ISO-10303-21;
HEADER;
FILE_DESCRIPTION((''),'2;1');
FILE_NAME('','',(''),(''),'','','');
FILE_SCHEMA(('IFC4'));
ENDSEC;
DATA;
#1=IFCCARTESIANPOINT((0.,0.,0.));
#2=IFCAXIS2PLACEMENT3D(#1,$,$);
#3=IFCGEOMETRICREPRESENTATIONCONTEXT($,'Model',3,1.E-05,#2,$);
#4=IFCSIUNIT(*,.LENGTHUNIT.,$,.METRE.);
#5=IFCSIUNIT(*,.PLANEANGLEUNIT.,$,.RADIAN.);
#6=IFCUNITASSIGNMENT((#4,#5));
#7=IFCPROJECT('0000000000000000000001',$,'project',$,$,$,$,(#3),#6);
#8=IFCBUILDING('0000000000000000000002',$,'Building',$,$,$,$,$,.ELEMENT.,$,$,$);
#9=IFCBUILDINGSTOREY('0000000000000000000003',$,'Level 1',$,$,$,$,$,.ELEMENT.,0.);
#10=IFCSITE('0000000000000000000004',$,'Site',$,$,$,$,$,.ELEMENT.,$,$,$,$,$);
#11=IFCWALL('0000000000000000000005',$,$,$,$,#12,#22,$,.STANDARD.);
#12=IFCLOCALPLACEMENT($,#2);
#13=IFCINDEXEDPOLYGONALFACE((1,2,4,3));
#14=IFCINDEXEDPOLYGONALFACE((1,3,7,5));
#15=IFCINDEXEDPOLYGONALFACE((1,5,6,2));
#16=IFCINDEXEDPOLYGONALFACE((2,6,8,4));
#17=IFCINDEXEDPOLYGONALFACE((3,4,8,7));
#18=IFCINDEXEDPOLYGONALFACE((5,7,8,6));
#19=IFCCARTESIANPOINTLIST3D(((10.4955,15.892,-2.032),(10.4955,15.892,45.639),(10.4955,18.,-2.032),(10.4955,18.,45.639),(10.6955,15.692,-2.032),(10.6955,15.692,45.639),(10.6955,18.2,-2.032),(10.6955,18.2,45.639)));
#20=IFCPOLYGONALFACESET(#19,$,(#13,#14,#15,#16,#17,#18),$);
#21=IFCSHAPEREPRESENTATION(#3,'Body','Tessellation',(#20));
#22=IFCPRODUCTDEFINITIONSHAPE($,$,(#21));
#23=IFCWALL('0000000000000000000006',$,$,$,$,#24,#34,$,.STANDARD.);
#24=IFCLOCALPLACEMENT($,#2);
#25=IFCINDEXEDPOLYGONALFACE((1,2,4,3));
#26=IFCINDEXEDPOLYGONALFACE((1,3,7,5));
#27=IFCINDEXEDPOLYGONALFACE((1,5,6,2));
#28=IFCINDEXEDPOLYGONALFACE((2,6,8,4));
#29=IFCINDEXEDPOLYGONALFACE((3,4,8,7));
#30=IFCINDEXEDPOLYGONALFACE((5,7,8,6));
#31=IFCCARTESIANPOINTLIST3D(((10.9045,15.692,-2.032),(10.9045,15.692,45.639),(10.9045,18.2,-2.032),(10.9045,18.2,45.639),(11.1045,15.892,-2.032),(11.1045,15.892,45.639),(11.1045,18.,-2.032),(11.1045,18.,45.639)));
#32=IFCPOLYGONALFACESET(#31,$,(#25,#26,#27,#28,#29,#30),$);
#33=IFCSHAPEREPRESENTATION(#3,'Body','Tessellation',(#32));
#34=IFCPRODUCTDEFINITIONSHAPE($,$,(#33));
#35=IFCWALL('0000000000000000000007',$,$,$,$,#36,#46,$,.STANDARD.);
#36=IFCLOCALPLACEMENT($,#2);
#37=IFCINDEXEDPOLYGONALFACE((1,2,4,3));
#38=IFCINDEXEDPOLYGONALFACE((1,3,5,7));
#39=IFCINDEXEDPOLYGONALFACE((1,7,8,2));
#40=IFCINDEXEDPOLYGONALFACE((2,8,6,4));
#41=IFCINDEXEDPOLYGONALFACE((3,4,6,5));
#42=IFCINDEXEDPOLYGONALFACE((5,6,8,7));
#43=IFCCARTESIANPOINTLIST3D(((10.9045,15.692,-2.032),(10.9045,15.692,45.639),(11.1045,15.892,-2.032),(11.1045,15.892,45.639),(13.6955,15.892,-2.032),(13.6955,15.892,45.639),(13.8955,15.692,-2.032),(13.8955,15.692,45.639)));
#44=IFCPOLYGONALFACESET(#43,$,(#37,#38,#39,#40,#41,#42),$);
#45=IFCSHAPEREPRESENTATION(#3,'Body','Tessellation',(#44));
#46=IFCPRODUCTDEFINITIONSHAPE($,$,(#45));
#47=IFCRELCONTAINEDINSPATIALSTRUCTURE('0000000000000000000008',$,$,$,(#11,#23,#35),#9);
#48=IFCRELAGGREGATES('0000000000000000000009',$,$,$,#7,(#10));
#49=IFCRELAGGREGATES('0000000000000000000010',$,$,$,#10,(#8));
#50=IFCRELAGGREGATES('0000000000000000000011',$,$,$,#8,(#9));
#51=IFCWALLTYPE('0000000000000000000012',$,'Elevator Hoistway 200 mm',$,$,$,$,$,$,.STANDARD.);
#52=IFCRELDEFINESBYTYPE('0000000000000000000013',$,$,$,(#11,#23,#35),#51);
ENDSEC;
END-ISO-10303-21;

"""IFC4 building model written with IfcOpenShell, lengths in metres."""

from ifc_helpers import new_model, si_unit, frame, origin, place, context, project, spatial, polyline, outline, extrude, type_object, element, save


model = new_model("IFC4")

# Units and contexts
model_context = context("Model", 3, precision=1e-05, world=origin())
ifc_project = project(units=[si_unit("LENGTHUNIT", "METRE"), si_unit("PLANEANGLEUNIT", "RADIAN")], contexts=[model_context])

# Site, building, storey
site = spatial("IfcSite", under=ifc_project, Name="Site", CompositionType="ELEMENT")
building = spatial("IfcBuilding", under=site, Name="Building", CompositionType="ELEMENT")
storey = spatial("IfcBuildingStorey", under=building, Name="Level 1", CompositionType="ELEMENT", Elevation=0.0)

# Wall
wall_type = type_object("IfcWallType", Name="Elevator Hoistway 200 mm", PredefinedType="STANDARD")
wall_1_placement = place(None, frame((10.5955, 15.792, -2.032), z_axis=(0.0, 0.0, 1.0), x_axis=(0.0, 1.0, 0.0)))
element("IfcWall", 1, at=wall_1_placement, inside=storey, type_object=wall_type, PredefinedType="STANDARD", context=model_context, shape_type="SweptSolid", body=[
    extrude(outline(polyline([(-0.1, -0.1), (2.408, -0.1), (2.208, 0.1), (0.1, 0.1), (-0.1, -0.1)])), origin(), (0.0, 0.0, 1.0), 47.671),
])

# Walls
wall_2_placement = place(None, frame((11.0045, 18.1, -2.032), z_axis=(0.0, 0.0, 1.0), x_axis=(0.0, -1.0, 0.0)))
element("IfcWall", 2, at=wall_2_placement, inside=storey, type_object=wall_type, PredefinedType="STANDARD", context=model_context, shape_type="SweptSolid", body=[
    extrude(outline(polyline([(-0.1, -0.1), (2.408, -0.1), (2.208, 0.1), (0.1, 0.1), (-0.1, -0.1)])), origin(), (0.0, 0.0, 1.0), 47.671),
])
wall_3_placement = place(None, frame((11.0045, 15.792, -2.032), z_axis=(0.0, 0.0, 1.0), x_axis=(1.0, 0.0, 0.0)))
element("IfcWall", 3, at=wall_3_placement, inside=storey, type_object=wall_type, PredefinedType="STANDARD", context=model_context, shape_type="SweptSolid", body=[
    extrude(outline(polyline([(-0.1, -0.1), (2.891, -0.1), (2.691, 0.1), (0.1, 0.1), (-0.1, -0.1)])), origin(), (0.0, 0.0, 1.0), 47.671),
])

save(model, "model.ifc")
